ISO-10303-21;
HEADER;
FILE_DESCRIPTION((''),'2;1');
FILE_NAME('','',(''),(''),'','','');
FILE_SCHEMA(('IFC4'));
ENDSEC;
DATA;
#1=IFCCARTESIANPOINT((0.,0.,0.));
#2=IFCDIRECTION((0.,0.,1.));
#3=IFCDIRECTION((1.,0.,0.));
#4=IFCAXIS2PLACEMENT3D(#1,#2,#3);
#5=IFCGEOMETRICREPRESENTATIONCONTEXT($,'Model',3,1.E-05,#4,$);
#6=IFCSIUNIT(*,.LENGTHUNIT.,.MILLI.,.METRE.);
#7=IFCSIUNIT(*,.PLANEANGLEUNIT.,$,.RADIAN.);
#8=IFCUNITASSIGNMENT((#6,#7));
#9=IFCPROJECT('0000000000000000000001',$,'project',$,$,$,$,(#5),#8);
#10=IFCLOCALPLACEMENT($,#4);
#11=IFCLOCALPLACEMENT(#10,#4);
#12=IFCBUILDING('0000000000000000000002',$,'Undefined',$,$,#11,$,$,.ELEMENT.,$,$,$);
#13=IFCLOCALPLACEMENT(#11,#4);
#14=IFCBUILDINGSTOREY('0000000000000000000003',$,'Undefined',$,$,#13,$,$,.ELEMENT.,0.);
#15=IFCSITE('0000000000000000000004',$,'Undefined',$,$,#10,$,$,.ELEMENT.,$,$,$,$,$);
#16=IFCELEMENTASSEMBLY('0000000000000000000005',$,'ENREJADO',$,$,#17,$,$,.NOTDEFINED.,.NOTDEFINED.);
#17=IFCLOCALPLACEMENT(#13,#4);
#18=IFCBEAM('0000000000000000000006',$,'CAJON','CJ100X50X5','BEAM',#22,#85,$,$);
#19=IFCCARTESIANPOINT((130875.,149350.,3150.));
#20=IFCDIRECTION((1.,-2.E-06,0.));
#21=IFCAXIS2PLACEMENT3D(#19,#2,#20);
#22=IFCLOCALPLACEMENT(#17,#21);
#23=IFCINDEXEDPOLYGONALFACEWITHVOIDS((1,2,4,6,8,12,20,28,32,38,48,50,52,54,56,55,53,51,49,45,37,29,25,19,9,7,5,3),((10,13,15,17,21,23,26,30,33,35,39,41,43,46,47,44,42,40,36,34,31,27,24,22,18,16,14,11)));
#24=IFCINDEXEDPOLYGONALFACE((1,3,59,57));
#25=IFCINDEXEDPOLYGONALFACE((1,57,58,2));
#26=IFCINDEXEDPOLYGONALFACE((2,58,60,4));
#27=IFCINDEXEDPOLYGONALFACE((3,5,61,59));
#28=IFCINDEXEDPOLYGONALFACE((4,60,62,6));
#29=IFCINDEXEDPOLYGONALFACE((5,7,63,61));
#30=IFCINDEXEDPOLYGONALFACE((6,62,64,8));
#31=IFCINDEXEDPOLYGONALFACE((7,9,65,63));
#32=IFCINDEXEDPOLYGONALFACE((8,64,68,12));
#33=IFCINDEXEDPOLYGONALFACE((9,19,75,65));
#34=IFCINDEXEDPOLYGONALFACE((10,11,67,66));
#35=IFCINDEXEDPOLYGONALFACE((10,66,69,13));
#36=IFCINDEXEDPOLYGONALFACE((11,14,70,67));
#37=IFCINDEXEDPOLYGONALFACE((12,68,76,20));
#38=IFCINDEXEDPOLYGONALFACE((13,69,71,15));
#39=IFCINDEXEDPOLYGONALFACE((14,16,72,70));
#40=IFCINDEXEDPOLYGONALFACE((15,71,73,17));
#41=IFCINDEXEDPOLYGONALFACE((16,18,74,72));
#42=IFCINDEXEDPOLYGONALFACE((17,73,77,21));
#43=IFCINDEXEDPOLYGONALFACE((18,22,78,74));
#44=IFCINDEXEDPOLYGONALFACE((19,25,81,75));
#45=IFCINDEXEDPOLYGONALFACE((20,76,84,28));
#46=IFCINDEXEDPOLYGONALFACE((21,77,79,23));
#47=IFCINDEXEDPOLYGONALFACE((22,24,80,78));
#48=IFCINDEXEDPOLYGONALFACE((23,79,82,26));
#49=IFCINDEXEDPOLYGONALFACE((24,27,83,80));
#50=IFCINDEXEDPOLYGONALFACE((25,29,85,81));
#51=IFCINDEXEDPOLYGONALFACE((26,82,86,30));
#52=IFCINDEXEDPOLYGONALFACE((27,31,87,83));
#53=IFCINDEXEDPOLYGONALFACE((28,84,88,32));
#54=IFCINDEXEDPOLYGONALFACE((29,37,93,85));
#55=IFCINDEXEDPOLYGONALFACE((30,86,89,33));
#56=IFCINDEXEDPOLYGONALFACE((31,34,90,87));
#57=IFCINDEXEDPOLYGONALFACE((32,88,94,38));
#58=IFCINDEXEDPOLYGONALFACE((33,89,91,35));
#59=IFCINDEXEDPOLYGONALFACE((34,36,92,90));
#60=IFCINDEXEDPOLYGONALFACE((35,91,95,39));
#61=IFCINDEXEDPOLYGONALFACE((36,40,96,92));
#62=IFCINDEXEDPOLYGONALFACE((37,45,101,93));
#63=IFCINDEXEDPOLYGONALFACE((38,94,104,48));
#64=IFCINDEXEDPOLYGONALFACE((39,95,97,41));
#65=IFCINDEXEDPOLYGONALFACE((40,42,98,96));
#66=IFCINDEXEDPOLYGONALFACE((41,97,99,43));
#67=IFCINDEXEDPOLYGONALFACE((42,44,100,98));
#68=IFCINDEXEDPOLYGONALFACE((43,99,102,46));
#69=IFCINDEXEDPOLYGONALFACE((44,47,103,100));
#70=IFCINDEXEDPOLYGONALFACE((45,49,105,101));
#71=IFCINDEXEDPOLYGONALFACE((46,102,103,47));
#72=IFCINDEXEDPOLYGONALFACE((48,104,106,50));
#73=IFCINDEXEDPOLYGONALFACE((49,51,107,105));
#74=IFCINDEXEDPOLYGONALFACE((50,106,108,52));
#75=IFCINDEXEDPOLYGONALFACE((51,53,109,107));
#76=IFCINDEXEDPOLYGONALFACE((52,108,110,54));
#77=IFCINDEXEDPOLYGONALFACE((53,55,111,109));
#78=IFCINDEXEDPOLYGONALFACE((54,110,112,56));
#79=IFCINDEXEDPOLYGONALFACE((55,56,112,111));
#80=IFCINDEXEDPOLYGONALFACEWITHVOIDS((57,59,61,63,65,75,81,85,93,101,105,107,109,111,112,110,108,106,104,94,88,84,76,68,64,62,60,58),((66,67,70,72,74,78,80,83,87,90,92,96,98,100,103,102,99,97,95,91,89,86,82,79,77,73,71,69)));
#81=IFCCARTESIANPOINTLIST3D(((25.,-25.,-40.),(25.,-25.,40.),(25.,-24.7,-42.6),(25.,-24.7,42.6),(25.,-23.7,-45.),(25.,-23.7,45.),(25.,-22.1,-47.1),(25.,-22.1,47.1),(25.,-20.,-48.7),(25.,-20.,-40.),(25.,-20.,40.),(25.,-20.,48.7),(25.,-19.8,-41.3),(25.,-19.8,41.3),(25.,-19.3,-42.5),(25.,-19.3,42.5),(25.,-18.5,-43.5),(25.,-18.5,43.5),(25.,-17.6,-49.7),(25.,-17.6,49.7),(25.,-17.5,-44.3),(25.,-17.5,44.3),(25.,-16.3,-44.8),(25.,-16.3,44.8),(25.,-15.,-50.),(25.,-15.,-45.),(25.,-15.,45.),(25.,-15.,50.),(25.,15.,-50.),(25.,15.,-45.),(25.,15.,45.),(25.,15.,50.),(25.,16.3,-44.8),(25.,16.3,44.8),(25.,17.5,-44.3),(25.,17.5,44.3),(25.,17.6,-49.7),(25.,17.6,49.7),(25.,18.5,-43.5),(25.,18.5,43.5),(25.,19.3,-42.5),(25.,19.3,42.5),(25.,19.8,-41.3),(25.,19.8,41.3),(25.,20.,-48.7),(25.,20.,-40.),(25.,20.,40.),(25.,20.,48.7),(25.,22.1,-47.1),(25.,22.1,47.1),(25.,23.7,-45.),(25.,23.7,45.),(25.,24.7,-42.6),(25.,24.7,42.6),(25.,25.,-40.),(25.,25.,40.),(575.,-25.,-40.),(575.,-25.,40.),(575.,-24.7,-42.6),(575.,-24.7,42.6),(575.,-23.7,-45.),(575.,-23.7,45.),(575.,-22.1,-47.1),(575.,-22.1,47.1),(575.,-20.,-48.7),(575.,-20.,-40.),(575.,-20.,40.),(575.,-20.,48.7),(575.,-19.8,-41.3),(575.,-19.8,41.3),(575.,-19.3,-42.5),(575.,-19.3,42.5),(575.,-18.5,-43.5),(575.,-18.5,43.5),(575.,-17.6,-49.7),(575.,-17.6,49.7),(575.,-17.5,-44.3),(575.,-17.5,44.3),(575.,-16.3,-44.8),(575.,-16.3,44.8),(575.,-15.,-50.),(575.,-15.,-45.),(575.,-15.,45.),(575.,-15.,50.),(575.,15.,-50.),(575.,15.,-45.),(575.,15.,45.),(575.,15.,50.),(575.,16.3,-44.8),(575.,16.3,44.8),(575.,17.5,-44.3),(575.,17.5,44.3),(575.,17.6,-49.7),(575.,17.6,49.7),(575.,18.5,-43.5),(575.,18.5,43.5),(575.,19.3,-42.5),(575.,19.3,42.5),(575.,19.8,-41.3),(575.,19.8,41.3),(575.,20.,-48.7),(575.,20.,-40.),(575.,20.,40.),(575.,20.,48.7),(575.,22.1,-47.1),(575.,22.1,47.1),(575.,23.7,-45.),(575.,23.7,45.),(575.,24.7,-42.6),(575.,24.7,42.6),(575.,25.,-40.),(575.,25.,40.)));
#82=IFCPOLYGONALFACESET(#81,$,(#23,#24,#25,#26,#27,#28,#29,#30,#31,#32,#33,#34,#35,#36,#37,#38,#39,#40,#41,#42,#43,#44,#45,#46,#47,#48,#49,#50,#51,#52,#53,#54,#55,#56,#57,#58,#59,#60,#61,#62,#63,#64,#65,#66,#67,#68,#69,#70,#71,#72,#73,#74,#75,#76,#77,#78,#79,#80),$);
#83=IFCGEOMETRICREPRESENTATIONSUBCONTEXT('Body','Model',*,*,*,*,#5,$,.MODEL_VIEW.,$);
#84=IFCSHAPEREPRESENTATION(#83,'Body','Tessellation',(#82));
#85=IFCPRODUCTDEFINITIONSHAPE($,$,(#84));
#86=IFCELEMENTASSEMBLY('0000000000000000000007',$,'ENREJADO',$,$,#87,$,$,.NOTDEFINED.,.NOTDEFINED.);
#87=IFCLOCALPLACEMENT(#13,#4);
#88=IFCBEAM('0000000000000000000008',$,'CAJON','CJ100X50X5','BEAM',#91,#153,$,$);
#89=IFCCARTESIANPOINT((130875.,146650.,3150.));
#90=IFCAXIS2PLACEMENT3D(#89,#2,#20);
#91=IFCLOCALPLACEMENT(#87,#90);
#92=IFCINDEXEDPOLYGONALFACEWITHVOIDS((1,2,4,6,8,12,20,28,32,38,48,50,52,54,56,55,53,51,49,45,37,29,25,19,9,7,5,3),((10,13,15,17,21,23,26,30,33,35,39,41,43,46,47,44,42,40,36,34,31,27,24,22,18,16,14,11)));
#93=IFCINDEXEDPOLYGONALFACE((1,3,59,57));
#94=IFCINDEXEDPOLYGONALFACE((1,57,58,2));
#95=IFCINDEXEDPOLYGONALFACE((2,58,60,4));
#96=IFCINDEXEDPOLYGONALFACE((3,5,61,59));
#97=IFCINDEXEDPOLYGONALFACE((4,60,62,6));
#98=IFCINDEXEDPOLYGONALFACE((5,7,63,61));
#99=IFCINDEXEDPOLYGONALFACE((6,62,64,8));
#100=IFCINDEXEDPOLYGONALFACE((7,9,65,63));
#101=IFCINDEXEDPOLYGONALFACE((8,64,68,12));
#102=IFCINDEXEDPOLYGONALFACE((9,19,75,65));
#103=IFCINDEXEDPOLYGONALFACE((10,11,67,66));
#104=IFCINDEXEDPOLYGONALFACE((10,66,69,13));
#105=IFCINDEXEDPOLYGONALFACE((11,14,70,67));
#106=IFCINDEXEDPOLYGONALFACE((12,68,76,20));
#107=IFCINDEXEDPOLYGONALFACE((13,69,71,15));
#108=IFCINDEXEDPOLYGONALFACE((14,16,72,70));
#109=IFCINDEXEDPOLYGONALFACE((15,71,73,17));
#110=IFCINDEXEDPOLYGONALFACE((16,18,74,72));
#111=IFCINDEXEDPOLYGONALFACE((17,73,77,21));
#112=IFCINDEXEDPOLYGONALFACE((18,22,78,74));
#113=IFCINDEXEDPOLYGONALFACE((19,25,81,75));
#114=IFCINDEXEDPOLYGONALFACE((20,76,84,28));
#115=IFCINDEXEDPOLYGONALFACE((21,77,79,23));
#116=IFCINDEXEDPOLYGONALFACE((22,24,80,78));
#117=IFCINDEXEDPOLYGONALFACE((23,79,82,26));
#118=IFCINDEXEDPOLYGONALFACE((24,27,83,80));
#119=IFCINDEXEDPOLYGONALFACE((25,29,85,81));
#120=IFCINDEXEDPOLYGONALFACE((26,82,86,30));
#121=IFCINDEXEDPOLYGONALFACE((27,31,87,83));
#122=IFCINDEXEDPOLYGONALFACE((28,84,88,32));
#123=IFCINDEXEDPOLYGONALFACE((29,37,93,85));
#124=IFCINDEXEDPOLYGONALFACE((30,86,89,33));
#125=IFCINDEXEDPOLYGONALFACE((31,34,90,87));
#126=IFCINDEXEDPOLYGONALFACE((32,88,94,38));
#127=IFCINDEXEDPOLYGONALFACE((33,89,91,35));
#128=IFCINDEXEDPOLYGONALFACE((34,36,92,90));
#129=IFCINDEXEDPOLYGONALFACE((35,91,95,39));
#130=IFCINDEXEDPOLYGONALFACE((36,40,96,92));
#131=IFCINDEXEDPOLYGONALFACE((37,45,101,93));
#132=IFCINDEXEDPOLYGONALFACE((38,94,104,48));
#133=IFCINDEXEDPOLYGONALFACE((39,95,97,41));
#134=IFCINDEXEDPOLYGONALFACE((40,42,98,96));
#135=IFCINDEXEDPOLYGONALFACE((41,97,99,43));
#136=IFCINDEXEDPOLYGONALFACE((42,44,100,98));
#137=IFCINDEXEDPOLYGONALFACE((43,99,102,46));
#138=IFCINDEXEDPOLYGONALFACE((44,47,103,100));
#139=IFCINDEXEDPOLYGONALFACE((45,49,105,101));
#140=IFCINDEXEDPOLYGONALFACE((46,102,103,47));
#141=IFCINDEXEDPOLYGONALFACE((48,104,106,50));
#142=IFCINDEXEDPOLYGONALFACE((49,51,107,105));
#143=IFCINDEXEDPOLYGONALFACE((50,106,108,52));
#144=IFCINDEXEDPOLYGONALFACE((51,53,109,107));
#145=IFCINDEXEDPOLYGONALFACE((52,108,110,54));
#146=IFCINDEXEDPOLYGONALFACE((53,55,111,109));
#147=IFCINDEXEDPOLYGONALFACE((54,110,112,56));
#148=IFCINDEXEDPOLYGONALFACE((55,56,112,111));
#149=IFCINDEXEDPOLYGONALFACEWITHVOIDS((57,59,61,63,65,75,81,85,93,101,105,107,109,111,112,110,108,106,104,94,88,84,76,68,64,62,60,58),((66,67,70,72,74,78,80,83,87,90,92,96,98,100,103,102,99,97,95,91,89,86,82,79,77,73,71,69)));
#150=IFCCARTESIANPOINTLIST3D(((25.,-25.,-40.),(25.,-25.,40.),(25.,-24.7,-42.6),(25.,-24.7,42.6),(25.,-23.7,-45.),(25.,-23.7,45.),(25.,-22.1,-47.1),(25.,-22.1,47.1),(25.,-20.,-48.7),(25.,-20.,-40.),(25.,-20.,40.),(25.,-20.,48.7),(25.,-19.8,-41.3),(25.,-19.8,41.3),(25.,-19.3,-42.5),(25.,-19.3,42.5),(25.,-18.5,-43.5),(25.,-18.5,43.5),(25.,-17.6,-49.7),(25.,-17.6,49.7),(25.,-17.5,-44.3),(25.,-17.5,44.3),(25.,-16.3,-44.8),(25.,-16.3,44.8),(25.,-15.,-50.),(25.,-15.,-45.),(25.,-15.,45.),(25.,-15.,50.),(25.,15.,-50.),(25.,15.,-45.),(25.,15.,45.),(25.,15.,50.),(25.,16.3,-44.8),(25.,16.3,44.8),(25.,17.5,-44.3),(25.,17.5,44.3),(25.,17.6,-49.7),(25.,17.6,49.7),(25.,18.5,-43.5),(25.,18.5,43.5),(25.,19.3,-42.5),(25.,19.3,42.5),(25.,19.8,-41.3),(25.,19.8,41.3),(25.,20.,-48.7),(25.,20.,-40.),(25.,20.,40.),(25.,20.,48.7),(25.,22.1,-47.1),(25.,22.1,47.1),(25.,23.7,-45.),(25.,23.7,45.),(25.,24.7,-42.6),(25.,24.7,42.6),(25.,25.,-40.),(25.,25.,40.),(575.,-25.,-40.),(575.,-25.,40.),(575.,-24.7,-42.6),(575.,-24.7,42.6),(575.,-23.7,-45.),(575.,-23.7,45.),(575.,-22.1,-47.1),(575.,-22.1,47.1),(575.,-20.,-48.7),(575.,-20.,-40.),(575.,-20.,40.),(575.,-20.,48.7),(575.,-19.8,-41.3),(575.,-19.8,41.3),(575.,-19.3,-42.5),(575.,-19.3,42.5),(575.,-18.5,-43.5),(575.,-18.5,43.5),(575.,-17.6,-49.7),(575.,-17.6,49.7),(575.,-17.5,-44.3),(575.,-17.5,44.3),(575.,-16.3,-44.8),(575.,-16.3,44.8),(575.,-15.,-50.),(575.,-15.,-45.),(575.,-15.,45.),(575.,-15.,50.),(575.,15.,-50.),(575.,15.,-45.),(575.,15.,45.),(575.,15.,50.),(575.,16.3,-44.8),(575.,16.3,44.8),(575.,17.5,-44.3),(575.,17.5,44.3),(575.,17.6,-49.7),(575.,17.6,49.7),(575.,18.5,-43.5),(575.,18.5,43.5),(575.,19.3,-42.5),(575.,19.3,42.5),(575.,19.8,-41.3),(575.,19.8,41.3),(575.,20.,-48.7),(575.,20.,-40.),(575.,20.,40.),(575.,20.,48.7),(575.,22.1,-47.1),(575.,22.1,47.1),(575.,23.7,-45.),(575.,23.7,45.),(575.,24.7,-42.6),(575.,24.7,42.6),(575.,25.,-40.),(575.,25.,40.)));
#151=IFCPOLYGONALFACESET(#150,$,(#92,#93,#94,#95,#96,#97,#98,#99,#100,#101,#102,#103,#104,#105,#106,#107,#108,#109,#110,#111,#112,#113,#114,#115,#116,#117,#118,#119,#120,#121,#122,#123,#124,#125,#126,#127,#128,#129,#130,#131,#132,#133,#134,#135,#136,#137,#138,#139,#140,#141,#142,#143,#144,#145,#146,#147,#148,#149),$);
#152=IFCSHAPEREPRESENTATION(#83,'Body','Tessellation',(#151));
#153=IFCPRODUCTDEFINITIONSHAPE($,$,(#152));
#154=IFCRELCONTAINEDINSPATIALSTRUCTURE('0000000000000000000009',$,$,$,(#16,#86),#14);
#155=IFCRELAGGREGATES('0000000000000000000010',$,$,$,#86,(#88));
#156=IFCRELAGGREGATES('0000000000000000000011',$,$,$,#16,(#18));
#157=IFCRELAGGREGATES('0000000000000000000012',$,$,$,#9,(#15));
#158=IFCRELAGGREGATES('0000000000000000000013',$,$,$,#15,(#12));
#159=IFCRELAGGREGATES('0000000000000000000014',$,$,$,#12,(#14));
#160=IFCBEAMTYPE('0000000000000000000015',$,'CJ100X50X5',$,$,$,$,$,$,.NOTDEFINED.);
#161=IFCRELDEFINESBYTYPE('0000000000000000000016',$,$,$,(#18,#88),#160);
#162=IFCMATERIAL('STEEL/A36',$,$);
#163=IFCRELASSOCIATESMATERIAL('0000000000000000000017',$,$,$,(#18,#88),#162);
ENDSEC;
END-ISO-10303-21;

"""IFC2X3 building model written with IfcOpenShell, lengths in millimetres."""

from ifc_helpers import new_model, si_unit, frame, origin_with_axes, origin_2d_with_axis, place, context, subcontext, project, spatial, hollow_rectangle, extrude, clip, halfspace, material, type_object, element, aggregate, save


model = new_model("IFC2X3")

# Units and contexts
model_context = context("Model", 3, precision=1e-05, world=origin_with_axes())
body_context = subcontext(model_context, "Body", "Model", "MODEL_VIEW")
ifc_project = project(units=[si_unit("LENGTHUNIT", "METRE", prefix="MILLI"), si_unit("PLANEANGLEUNIT", "RADIAN")], contexts=[model_context])

# Site, building, storey
site_placement = place(None, origin_with_axes())
site = spatial("IfcSite", under=ifc_project, at=site_placement, Name="Undefined", CompositionType="ELEMENT")
building_placement = place(site_placement, origin_with_axes())
building = spatial("IfcBuilding", under=site, at=building_placement, Name="Undefined", CompositionType="ELEMENT")
storey_placement = place(building_placement, origin_with_axes())
storey = spatial("IfcBuildingStorey", under=building, at=storey_placement, Name="Undefined", CompositionType="ELEMENT", Elevation=0.0)

# Shared definitions
ifc_material_1 = material(Name="STEEL/A36")

# Element assembly, beam
assembly_1_placement = place(storey_placement, origin_with_axes())
assembly_1 = element("IfcElementAssembly", 1, at=assembly_1_placement, inside=storey, Name="ENREJADO", AssemblyPlace="NOTDEFINED", PredefinedType="NOTDEFINED")
beam_type_1 = type_object("IfcBeamType", Name="CJ100X50X5", PredefinedType="NOTDEFINED")
beam_1_placement = place(assembly_1_placement, frame((130875.0, 149350.0, 3150.0), z_axis=(0.0, 0.0, 1.0), x_axis=(1.0, -0.000002, 0.0)))
beam_1 = element("IfcBeam", 2, at=beam_1_placement, type_object=beam_type_1, material=ifc_material_1, Name="CAJON", Description="CJ100X50X5", ObjectType="BEAM", context=body_context, shape_type="Clipping", body=[
    clip(clip(extrude(hollow_rectangle(XDim=50.0, YDim=100.0, WallThickness=5.0, InnerFilletRadius=5.0, OuterFilletRadius=10.0, at=origin_2d_with_axis()), frame((600.0, 0.0, 0.0), z_axis=(-1.0, 0.0, 0.0), x_axis=(0.0, -1.0, 0.0)), (0.0, 0.0, 1.0), 600.0), halfspace(frame((575.0, -25.0, 1050.0), z_axis=(1.0, 0.000003, 0.0), x_axis=(-0.000002, 1.0, 0.0)), False)), halfspace(frame((25.0, 25.0, 1050.0), z_axis=(-1.0, -0.000002, 0.0), x_axis=(0.000003, -1.0, 0.0)), False)),
])

# Element assembly, beam
assembly_2_placement = place(storey_placement, origin_with_axes())
assembly_2 = element("IfcElementAssembly", 3, at=assembly_2_placement, inside=storey, Name="ENREJADO", AssemblyPlace="NOTDEFINED", PredefinedType="NOTDEFINED")
beam_2_placement = place(assembly_2_placement, frame((130875.0, 146650.0, 3150.0), z_axis=(0.0, 0.0, 1.0), x_axis=(1.0, -0.000002, 0.0)))
beam_2 = element("IfcBeam", 4, at=beam_2_placement, type_object=beam_type_1, material=ifc_material_1, Name="CAJON", Description="CJ100X50X5", ObjectType="BEAM", context=body_context, shape_type="Clipping", body=[
    clip(clip(extrude(hollow_rectangle(XDim=50.0, YDim=100.0, WallThickness=5.0, InnerFilletRadius=5.0, OuterFilletRadius=10.0, at=origin_2d_with_axis()), frame((600.0, 0.0, 0.0), z_axis=(-1.0, 0.0, 0.0), x_axis=(0.0, -1.0, 0.0)), (0.0, 0.0, 1.0), 600.0), halfspace(frame((575.0, -25.0, 1050.0), z_axis=(1.0, 0.000003, 0.0), x_axis=(-0.000002, 1.0, 0.0)), False)), halfspace(frame((25.0, 25.0, 1050.0), z_axis=(-1.0, -0.000002, 0.0), x_axis=(0.000003, -1.0, 0.0)), False)),
])

aggregate(assembly_2, [beam_2])
aggregate(assembly_1, [beam_1])

save(model, "model.ifc")
